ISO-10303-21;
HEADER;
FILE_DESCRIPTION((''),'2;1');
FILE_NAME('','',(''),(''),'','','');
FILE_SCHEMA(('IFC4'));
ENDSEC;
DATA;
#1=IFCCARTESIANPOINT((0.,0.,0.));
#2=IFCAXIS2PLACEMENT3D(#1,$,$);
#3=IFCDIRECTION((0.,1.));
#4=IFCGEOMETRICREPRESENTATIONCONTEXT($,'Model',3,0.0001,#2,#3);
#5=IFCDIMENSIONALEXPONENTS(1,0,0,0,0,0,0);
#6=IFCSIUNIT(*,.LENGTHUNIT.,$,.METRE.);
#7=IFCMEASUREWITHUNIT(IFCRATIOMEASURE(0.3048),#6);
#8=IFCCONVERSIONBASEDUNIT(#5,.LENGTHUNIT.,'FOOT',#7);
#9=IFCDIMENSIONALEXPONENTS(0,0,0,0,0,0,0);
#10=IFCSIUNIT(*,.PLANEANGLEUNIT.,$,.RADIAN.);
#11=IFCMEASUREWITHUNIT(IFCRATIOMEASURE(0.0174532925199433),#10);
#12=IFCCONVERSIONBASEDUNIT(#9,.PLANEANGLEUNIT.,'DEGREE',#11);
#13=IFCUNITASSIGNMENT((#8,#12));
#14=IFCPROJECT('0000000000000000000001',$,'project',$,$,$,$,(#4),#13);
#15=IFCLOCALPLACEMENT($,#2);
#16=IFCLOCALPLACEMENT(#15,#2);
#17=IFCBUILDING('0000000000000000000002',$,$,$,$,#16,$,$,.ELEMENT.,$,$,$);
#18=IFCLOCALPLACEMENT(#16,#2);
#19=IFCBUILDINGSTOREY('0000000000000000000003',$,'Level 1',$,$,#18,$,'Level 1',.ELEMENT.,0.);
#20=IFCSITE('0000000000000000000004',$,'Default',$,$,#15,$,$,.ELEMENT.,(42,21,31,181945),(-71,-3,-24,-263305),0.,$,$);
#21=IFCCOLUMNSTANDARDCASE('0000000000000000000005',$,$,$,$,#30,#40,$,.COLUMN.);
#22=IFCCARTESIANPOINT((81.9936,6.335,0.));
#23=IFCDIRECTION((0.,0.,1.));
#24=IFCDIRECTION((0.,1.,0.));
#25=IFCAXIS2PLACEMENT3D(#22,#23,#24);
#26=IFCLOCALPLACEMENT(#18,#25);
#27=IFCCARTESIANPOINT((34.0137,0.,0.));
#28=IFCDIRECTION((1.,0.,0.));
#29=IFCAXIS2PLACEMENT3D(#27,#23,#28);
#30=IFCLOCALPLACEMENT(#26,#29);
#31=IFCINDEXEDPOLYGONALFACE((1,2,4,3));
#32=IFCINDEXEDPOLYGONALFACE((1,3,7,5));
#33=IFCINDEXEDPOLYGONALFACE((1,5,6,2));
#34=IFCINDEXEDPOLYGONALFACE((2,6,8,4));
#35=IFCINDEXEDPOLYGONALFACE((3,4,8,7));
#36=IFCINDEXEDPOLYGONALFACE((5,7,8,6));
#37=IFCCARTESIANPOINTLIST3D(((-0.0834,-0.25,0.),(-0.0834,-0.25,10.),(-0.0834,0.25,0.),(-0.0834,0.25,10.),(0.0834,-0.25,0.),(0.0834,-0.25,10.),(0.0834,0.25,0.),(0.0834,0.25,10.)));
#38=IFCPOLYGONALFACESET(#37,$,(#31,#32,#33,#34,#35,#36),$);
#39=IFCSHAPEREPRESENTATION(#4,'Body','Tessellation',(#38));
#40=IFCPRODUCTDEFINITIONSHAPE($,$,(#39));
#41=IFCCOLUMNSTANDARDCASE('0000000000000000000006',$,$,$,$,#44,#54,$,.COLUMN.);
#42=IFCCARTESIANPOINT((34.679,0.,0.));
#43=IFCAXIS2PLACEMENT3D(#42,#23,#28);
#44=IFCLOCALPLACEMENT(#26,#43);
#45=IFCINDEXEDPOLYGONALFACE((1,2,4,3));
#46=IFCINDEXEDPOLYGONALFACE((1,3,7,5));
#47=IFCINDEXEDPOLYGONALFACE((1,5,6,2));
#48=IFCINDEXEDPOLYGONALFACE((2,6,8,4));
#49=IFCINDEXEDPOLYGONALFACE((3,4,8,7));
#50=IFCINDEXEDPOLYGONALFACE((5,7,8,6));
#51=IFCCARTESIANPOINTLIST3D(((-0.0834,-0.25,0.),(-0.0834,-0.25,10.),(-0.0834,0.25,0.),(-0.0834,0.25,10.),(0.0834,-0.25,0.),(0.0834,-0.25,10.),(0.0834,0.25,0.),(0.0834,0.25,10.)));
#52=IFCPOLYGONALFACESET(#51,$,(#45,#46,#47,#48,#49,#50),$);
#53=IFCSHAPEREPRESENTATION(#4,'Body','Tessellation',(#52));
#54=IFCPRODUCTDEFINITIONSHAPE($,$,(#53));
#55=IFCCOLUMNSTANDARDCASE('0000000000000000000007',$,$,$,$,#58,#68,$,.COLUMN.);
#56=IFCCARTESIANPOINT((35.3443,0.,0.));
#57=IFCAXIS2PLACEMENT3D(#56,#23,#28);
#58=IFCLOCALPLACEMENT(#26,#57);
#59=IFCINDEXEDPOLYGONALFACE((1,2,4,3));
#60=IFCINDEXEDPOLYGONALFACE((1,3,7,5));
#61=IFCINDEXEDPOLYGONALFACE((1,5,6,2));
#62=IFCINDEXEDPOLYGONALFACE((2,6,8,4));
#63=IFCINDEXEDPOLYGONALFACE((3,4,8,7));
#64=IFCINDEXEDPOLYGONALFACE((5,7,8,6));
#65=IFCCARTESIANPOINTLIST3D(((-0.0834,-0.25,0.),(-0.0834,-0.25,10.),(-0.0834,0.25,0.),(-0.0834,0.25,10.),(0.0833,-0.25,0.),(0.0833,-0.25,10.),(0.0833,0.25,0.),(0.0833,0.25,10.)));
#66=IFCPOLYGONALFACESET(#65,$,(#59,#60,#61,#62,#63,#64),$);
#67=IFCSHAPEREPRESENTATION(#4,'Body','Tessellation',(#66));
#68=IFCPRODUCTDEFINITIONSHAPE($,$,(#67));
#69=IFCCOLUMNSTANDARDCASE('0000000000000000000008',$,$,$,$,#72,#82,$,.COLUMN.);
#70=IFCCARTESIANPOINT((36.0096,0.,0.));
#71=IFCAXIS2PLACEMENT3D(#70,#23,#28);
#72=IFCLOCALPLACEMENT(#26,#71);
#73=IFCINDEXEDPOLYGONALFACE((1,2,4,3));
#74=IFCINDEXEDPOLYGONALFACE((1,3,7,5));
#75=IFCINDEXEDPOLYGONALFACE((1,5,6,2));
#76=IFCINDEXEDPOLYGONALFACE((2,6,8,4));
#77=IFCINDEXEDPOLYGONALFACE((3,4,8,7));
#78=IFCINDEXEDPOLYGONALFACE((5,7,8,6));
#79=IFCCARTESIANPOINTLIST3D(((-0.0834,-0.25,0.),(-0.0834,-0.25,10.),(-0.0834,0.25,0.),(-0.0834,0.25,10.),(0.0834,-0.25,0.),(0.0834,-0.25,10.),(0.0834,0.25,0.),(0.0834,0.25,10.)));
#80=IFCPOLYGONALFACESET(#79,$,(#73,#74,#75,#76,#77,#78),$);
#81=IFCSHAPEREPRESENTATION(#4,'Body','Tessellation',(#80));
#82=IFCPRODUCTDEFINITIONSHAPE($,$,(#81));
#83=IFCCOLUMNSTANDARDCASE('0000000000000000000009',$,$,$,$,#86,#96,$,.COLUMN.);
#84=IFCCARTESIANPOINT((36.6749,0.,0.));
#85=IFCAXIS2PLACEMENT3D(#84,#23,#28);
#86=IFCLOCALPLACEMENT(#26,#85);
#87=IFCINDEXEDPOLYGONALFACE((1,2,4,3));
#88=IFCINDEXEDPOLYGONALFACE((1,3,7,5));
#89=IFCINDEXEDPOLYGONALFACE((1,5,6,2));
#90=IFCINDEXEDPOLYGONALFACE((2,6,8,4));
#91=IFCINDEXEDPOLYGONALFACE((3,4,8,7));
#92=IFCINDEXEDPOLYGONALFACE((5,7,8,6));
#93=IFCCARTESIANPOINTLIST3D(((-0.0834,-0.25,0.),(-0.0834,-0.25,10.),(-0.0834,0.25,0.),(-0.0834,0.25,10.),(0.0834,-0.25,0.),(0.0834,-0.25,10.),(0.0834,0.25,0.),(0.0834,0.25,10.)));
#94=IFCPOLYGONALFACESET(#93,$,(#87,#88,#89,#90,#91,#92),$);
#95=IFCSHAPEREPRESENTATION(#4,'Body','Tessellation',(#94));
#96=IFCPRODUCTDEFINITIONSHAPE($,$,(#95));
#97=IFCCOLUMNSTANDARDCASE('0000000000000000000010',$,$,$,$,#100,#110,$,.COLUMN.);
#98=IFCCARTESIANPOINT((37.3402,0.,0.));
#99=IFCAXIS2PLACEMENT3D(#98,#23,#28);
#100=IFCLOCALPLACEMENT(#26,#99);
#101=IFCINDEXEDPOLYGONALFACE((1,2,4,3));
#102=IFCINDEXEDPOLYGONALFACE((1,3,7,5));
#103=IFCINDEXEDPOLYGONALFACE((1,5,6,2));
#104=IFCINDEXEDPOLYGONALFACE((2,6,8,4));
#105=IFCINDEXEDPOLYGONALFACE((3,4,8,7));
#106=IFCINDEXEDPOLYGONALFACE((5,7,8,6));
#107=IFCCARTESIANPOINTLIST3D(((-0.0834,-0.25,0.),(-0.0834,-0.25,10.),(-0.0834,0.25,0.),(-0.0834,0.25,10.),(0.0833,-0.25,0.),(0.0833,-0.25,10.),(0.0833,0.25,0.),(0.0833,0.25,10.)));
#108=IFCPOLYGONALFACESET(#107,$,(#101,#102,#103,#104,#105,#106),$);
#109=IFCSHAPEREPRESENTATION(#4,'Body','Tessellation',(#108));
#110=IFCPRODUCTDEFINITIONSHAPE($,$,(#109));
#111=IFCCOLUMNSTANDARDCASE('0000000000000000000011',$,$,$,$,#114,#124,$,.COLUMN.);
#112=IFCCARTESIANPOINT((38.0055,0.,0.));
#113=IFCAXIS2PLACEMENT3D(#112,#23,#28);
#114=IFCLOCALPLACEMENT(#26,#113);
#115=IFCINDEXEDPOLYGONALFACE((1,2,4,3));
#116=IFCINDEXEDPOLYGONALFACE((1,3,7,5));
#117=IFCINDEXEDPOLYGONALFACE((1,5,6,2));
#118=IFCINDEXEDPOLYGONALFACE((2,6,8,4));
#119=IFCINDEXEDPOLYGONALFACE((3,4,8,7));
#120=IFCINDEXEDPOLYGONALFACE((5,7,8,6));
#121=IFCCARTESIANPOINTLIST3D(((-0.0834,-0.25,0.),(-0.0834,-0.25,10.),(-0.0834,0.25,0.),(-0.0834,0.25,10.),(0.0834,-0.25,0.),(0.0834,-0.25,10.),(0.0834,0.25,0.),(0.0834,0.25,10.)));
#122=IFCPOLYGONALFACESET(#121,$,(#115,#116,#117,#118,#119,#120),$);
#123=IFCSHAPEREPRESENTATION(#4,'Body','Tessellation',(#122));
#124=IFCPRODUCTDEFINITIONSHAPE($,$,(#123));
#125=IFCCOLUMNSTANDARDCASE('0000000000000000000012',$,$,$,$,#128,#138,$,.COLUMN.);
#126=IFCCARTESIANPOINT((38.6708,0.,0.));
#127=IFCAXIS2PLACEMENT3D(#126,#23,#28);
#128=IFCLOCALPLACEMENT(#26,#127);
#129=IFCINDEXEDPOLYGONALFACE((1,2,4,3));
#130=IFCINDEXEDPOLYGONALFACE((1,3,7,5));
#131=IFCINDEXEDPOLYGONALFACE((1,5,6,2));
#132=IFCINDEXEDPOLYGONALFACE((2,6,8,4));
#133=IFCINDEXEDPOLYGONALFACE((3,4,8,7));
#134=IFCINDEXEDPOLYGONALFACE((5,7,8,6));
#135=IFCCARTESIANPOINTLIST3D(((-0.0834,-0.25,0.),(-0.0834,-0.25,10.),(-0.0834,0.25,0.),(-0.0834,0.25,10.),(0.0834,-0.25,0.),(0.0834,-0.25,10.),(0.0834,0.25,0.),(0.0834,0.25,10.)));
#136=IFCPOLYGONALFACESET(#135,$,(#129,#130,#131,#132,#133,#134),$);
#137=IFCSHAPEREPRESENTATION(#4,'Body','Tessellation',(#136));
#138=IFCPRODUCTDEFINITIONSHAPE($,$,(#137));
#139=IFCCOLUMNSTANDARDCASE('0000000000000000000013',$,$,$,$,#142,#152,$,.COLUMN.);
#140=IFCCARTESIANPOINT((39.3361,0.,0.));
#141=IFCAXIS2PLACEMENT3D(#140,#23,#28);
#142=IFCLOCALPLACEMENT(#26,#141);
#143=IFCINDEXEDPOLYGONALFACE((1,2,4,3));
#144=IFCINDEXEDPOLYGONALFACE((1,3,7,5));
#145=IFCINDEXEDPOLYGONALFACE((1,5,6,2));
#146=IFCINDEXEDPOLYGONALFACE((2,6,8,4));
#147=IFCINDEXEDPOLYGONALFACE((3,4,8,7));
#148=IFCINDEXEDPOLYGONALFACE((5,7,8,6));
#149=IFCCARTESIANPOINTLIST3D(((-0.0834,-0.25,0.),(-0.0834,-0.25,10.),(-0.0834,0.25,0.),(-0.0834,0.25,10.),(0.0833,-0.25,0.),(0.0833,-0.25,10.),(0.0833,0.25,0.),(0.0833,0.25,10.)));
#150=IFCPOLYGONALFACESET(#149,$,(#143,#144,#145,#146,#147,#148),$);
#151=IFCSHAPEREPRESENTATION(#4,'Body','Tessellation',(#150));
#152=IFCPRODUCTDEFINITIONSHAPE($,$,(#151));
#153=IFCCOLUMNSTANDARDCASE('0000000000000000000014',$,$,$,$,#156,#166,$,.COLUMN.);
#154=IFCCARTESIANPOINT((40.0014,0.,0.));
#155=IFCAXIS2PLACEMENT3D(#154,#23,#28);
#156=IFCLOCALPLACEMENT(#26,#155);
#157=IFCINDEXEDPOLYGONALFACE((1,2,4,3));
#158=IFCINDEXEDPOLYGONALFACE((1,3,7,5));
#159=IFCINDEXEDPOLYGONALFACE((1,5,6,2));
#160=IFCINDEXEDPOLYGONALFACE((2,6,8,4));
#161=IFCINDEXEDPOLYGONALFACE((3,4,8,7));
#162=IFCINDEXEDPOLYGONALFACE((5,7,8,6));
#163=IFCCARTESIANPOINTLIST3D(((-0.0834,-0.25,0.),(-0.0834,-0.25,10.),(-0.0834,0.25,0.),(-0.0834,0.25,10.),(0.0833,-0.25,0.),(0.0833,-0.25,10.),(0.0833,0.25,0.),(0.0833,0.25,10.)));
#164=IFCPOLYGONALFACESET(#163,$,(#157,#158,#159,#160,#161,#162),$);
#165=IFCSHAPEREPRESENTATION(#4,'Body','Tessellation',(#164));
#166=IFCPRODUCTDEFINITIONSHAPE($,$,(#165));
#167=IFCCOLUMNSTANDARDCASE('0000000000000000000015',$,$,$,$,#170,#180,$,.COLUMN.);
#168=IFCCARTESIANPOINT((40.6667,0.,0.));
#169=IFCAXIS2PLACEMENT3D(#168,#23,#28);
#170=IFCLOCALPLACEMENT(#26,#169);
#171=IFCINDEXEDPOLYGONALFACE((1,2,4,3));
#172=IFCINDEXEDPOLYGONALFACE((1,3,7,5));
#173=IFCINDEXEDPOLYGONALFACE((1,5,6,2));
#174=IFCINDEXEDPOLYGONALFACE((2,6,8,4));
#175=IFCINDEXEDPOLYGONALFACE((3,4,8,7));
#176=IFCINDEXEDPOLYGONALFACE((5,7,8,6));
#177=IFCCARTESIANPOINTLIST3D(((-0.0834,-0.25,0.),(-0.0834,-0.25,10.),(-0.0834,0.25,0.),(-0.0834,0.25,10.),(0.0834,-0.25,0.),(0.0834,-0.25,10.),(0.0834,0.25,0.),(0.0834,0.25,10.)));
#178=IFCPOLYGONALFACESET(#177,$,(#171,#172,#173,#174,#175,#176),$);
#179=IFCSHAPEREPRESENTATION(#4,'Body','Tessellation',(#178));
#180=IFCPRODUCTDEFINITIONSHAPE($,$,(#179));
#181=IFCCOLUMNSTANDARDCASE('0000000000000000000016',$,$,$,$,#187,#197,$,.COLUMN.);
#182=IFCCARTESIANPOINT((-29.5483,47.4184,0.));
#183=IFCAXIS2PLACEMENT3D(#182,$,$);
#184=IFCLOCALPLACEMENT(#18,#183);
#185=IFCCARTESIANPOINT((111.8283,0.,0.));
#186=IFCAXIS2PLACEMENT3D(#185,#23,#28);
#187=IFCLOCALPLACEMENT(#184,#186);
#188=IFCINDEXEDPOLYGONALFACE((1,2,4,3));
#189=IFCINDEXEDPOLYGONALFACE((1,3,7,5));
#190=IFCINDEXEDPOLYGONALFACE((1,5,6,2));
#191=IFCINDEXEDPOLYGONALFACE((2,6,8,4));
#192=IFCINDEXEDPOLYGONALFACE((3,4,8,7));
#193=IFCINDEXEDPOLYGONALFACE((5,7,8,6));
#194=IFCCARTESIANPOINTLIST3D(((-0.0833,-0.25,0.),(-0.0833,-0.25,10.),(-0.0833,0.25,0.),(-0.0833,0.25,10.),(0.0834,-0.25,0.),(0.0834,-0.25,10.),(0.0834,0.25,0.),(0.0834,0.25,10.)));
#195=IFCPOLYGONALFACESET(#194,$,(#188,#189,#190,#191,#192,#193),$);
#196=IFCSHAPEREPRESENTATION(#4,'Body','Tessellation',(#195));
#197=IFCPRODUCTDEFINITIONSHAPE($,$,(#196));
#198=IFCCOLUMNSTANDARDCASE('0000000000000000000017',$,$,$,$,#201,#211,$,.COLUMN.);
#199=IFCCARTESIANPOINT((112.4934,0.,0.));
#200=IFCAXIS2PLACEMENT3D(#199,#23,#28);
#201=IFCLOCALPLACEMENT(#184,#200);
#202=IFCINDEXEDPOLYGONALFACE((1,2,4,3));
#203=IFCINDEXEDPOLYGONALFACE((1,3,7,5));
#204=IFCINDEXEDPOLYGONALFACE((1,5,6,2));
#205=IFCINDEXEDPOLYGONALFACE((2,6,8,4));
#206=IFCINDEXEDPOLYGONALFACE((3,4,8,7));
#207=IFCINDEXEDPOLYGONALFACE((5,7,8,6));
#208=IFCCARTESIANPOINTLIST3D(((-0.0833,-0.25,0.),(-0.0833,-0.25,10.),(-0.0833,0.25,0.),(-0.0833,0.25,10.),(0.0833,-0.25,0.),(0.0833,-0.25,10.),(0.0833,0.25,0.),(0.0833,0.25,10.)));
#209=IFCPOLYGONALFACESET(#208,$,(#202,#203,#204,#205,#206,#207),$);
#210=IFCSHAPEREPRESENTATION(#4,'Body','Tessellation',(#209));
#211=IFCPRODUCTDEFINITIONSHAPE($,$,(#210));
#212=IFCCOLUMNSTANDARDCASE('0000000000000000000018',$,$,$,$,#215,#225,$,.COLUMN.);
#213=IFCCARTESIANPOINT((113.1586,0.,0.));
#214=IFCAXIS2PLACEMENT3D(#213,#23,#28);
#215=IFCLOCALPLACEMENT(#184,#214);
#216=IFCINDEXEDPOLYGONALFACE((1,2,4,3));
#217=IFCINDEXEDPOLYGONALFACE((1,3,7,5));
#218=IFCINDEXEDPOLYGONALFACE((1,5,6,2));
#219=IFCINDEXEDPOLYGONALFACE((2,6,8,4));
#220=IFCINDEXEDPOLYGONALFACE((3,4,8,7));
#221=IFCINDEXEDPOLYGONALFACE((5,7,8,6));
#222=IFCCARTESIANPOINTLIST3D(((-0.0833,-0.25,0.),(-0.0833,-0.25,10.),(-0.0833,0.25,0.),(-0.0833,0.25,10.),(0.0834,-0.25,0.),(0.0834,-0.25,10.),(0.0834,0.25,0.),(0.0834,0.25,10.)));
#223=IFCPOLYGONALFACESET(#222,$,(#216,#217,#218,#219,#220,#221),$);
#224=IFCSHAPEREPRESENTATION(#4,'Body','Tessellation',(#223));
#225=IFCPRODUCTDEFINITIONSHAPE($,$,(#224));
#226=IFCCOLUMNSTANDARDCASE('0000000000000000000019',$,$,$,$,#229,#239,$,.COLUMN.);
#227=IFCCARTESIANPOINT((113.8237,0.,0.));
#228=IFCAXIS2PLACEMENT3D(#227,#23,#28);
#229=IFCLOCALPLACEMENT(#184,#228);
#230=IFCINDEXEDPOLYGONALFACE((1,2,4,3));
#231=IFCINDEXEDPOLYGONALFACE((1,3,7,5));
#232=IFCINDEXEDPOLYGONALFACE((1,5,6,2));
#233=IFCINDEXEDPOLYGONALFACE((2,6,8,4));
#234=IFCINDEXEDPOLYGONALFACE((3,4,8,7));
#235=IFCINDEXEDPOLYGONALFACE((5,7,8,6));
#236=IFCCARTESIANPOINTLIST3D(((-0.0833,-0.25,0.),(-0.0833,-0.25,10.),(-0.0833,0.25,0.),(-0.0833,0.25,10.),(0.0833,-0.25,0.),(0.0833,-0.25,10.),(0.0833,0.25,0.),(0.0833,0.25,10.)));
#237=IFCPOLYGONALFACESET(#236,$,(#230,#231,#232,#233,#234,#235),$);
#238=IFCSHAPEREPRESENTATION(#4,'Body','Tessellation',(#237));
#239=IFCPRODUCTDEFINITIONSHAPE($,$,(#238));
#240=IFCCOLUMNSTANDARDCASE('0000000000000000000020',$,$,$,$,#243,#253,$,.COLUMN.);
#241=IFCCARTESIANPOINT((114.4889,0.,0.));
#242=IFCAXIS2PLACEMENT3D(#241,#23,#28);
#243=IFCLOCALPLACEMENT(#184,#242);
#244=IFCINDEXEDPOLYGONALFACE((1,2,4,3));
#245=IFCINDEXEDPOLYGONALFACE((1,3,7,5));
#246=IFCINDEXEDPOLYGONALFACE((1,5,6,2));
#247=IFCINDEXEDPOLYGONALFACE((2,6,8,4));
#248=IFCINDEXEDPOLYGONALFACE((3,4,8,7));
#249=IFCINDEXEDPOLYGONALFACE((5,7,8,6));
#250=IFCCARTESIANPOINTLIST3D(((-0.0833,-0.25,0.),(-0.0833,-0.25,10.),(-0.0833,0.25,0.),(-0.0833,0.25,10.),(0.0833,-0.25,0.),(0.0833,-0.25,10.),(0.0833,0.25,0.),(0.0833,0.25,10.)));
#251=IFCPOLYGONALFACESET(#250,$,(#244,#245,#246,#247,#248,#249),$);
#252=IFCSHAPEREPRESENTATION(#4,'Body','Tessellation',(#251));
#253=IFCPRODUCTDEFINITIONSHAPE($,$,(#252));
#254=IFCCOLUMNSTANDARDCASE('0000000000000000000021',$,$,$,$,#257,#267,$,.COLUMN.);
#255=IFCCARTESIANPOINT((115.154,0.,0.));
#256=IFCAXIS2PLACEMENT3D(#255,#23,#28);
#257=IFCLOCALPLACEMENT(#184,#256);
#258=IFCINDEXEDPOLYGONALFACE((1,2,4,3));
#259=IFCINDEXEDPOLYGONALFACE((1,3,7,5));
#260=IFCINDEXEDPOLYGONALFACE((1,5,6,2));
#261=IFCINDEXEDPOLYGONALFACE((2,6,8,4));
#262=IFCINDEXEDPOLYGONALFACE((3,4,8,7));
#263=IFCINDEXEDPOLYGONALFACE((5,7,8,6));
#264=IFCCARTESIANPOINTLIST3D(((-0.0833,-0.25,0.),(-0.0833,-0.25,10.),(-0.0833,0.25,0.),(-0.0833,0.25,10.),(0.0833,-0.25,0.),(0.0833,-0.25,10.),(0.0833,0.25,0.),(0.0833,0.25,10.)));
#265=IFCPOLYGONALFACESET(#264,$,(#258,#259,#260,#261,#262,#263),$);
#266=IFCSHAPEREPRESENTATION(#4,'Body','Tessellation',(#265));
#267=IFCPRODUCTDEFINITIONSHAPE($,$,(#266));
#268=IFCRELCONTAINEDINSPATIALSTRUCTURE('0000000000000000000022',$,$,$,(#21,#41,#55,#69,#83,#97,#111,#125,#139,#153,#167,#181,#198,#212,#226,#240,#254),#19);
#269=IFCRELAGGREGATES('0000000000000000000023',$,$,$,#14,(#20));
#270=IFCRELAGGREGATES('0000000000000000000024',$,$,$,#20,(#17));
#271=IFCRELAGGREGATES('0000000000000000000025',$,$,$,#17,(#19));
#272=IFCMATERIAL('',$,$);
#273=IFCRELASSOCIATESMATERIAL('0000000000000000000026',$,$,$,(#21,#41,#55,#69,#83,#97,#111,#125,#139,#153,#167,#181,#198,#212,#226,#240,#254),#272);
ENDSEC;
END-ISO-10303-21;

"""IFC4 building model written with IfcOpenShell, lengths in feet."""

from ifc_helpers import new_model, entity, si_unit, converted_unit, direction, frame, origin, place, context, project, spatial, rectangle, extrude, material, element, save


model = new_model("IFC4")

# Units and contexts
model_context = context("Model", 3, precision=0.0001, world=origin(), true_north=direction((0.0, 1.0)))
ifc_project = project(units=[converted_unit("LENGTHUNIT", "FOOT", entity("IfcRatioMeasure", 0.3048), si_unit("LENGTHUNIT", "METRE"), dimensions=[1, 0, 0, 0, 0, 0, 0]), converted_unit("PLANEANGLEUNIT", "DEGREE", entity("IfcRatioMeasure", 0.0174532925199433), si_unit("PLANEANGLEUNIT", "RADIAN"), dimensions=[0, 0, 0, 0, 0, 0, 0])], contexts=[model_context])

# Site, building, storey
site_placement = place(None, origin())
site = spatial("IfcSite", under=ifc_project, at=site_placement, Name="Default", CompositionType="ELEMENT", RefLatitude=(42, 21, 31, 181945), RefLongitude=(-71, -3, -24, -263305), RefElevation=0.0)
building_placement = place(site_placement, origin())
building = spatial("IfcBuilding", under=site, at=building_placement, CompositionType="ELEMENT")
storey_placement = place(building_placement, origin())
storey = spatial("IfcBuildingStorey", under=building, at=storey_placement, Name="Level 1", LongName="Level 1", CompositionType="ELEMENT", Elevation=0.0)

# Columns
ifc_material = material(Name="")
placement_1 = place(storey_placement, frame((81.9936, 6.335, 0.0), z_axis=(0.0, 0.0, 1.0), x_axis=(0.0, 1.0, 0.0)))
for number, where, z_axis, x_axis in (
    (1, (34.0137, 0.0, 0.0), (0.0, 0.0, 1.0), (1.0, 0.0, 0.0)),
    (2, (34.679, 0.0, 0.0), (0.0, 0.0, 1.0), (1.0, 0.0, 0.0)),
    (3, (35.3443, 0.0, 0.0), (0.0, 0.0, 1.0), (1.0, 0.0, 0.0)),
    (4, (36.0096, 0.0, 0.0), (0.0, 0.0, 1.0), (1.0, 0.0, 0.0)),
    (5, (36.6749, 0.0, 0.0), (0.0, 0.0, 1.0), (1.0, 0.0, 0.0)),
    (6, (37.3402, 0.0, 0.0), (0.0, 0.0, 1.0), (1.0, 0.0, 0.0)),
    (7, (38.0055, 0.0, 0.0), (0.0, 0.0, 1.0), (1.0, 0.0, 0.0)),
    (8, (38.6708, 0.0, 0.0), (0.0, 0.0, 1.0), (1.0, 0.0, 0.0)),
    (9, (39.3361, 0.0, 0.0), (0.0, 0.0, 1.0), (1.0, 0.0, 0.0)),
    (10, (40.0014, 0.0, 0.0), (0.0, 0.0, 1.0), (1.0, 0.0, 0.0)),
    (11, (40.6667, 0.0, 0.0), (0.0, 0.0, 1.0), (1.0, 0.0, 0.0)),
):
    element("IfcColumnStandardCase", number, at=place(placement_1, frame(where, z_axis=z_axis, x_axis=x_axis)), inside=storey, material=ifc_material, PredefinedType="COLUMN", context=model_context, shape_type="SweptSolid", body=[
        extrude(rectangle(XDim=0.1667, YDim=0.5), origin(), (0.0, 0.0, 1.0), 10.0),
    ])
placement_2 = place(storey_placement, frame((-29.5483, 47.4184, 0.0)))
for number, where, z_axis, x_axis in (
    (12, (111.8283, 0.0, 0.0), (0.0, 0.0, 1.0), (1.0, 0.0, 0.0)),
    (13, (112.4934, 0.0, 0.0), (0.0, 0.0, 1.0), (1.0, 0.0, 0.0)),
    (14, (113.1586, 0.0, 0.0), (0.0, 0.0, 1.0), (1.0, 0.0, 0.0)),
    (15, (113.8237, 0.0, 0.0), (0.0, 0.0, 1.0), (1.0, 0.0, 0.0)),
    (16, (114.4889, 0.0, 0.0), (0.0, 0.0, 1.0), (1.0, 0.0, 0.0)),
    (17, (115.154, 0.0, 0.0), (0.0, 0.0, 1.0), (1.0, 0.0, 0.0)),
):
    element("IfcColumnStandardCase", number, at=place(placement_2, frame(where, z_axis=z_axis, x_axis=x_axis)), inside=storey, material=ifc_material, PredefinedType="COLUMN", context=model_context, shape_type="SweptSolid", body=[
        extrude(rectangle(XDim=0.1667, YDim=0.5), origin(), (0.0, 0.0, 1.0), 10.0),
    ])

save(model, "model.ifc")
